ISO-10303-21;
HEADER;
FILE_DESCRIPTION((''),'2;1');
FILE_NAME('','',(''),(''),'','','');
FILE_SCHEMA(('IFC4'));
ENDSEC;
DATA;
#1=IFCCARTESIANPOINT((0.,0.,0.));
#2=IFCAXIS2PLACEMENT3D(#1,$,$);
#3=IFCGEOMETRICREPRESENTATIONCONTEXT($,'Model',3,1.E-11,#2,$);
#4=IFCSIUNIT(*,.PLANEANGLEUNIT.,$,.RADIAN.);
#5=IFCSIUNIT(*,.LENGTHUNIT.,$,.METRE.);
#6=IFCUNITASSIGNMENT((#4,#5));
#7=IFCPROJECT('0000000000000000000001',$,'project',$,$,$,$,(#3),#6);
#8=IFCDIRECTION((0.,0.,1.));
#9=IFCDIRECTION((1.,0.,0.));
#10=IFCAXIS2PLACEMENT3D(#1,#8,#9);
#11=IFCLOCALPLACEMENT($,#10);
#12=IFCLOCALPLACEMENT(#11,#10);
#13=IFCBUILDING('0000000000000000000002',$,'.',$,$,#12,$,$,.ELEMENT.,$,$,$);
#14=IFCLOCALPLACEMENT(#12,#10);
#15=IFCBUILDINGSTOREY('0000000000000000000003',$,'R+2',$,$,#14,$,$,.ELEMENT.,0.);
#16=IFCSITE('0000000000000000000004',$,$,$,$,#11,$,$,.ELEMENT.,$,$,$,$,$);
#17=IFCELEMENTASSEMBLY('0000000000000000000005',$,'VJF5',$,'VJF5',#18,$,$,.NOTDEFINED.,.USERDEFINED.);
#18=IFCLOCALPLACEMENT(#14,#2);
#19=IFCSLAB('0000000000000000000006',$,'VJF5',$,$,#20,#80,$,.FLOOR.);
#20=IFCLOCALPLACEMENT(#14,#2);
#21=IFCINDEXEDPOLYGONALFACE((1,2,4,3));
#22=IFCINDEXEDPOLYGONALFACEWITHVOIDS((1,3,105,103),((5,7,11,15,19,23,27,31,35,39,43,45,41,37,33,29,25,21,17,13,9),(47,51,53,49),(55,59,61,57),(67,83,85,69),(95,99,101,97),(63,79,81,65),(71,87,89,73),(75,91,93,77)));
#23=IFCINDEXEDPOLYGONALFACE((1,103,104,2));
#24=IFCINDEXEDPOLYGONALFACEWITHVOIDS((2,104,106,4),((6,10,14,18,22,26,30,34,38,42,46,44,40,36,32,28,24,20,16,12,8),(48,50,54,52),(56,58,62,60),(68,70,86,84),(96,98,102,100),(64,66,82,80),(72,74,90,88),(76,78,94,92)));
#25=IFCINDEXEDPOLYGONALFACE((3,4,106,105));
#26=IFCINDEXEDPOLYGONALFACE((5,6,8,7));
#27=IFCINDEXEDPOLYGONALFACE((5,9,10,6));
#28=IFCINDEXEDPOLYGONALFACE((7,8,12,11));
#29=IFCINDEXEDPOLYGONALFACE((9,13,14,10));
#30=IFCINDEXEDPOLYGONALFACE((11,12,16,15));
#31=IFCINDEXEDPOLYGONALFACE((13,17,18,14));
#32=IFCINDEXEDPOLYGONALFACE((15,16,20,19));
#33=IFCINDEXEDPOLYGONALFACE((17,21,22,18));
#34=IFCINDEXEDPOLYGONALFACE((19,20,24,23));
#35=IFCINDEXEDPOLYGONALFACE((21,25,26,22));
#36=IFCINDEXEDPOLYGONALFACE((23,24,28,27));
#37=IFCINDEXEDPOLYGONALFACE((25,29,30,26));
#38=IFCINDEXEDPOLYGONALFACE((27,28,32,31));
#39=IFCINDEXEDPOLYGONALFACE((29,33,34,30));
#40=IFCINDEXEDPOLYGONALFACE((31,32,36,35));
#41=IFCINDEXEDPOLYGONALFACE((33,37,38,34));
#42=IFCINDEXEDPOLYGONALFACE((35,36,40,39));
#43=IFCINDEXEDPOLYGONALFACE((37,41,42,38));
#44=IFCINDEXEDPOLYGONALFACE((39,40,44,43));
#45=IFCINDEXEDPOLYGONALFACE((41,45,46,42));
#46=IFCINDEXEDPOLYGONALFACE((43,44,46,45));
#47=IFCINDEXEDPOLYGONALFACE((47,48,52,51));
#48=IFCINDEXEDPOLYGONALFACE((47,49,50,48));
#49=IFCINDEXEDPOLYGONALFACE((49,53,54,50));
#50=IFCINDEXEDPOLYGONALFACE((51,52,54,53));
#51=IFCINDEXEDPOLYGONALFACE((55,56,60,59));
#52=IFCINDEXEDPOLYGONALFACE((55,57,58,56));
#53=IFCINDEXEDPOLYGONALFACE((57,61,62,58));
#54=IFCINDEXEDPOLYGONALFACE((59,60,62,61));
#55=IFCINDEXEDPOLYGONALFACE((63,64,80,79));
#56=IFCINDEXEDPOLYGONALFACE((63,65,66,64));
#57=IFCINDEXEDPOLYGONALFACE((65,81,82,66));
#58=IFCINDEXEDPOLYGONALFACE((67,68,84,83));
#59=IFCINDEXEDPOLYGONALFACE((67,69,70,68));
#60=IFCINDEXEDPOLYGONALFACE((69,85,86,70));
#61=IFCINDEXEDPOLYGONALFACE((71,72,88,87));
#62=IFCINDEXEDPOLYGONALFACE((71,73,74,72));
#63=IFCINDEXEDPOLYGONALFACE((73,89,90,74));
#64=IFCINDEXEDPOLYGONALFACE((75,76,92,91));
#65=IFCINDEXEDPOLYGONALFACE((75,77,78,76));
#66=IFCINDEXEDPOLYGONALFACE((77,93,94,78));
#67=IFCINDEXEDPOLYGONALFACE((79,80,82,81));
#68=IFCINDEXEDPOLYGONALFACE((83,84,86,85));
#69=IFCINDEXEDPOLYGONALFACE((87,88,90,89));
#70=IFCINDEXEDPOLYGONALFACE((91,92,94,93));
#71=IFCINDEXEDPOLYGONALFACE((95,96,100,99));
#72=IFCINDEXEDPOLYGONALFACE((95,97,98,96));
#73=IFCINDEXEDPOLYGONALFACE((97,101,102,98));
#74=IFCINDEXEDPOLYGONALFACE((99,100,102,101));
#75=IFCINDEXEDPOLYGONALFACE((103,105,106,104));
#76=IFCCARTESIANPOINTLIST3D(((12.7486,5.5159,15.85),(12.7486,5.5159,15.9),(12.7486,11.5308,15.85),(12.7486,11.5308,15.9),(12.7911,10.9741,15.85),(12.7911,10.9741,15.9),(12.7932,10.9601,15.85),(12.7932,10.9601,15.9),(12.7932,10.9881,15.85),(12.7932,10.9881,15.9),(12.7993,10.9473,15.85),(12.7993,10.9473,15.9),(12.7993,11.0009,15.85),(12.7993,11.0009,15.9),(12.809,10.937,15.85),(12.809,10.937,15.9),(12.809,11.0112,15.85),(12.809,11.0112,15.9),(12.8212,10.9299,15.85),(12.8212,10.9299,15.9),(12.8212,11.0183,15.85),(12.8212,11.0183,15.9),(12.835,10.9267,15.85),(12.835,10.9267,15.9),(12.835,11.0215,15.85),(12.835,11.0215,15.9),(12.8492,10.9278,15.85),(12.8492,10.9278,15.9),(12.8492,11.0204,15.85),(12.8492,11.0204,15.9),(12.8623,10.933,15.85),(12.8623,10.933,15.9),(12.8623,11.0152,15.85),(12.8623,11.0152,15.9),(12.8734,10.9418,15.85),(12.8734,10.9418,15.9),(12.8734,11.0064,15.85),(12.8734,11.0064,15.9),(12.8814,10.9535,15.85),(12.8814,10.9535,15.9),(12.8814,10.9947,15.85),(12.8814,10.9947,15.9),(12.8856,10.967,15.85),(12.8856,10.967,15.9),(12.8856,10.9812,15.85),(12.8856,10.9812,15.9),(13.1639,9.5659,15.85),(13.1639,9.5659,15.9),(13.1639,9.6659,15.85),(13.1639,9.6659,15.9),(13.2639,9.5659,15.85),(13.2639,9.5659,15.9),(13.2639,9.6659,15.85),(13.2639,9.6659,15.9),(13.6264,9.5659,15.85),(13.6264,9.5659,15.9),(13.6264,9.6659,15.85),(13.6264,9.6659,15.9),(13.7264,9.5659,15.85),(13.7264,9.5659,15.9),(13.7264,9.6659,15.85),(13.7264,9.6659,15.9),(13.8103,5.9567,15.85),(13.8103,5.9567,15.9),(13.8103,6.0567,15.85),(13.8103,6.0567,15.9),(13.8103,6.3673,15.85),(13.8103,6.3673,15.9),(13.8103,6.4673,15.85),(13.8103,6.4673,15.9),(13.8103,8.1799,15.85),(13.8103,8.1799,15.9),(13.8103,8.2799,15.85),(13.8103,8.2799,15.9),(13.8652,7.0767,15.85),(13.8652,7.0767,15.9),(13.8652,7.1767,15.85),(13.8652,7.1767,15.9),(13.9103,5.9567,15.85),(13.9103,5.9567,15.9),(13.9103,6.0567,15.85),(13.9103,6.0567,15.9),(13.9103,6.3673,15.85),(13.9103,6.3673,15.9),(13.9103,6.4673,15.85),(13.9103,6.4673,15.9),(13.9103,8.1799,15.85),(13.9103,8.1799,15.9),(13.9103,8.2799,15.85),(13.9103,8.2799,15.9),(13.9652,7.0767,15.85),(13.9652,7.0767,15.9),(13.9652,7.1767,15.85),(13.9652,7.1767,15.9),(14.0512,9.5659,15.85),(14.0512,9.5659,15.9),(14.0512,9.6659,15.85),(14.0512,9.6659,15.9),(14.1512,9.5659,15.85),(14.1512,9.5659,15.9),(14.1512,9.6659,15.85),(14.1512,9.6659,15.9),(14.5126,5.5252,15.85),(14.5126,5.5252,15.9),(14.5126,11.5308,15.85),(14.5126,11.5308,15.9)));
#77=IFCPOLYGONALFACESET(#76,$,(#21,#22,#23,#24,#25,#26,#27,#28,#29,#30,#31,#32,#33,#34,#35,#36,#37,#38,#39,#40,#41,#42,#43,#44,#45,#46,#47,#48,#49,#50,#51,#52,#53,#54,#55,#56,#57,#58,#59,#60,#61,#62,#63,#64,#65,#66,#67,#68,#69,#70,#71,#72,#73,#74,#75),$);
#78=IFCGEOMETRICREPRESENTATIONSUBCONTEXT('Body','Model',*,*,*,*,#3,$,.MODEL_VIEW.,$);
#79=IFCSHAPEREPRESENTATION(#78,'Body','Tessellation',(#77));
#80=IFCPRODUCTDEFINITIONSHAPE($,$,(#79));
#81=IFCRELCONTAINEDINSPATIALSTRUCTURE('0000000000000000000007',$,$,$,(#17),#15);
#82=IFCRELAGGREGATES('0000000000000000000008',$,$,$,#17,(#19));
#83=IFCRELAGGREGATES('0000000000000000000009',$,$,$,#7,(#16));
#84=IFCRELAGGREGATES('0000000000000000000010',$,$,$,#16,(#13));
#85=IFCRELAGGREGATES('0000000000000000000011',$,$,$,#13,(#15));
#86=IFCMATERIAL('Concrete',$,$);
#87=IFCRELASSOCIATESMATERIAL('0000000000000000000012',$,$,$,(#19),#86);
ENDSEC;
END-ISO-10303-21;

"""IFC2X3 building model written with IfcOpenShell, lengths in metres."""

from ifc_helpers import new_model, si_unit, frame, origin, origin_with_axes, origin_2d_with_axis, place, context, subcontext, project, spatial, polyline, circle, outline, extrude, material, element, aggregate, save


model = new_model("IFC2X3")

# Units and contexts
model_context = context("Model", 3, precision=1e-11, world=origin())
body_context = subcontext(model_context, "Body", "Model", "MODEL_VIEW")
ifc_project = project(units=[si_unit("PLANEANGLEUNIT", "RADIAN"), si_unit("LENGTHUNIT", "METRE")], contexts=[model_context])

# Site, building, storey
site_placement = place(None, origin_with_axes())
site = spatial("IfcSite", under=ifc_project, at=site_placement, CompositionType="ELEMENT")
building_placement = place(site_placement, origin_with_axes())
building = spatial("IfcBuilding", under=site, at=building_placement, Name=".", CompositionType="ELEMENT")
storey_placement = place(building_placement, origin_with_axes())
storey = spatial("IfcBuildingStorey", under=building, at=storey_placement, Name="R+2", CompositionType="ELEMENT", Elevation=0.0)

# Element assembly, slab, openings
assembly_placement = place(storey_placement, origin_with_axes())
assembly = element("IfcElementAssembly", 1, at=assembly_placement, inside=storey, Name="VJF5", ObjectType="VJF5", AssemblyPlace="NOTDEFINED", PredefinedType="USERDEFINED")
ifc_material = material(Name="Concrete")
slab_placement = place(assembly_placement, frame((14.5126, 5.5159, 15.85), z_axis=(0.0, 0.0, 1.0), x_axis=(0.0, 1.0, 0.0)))
slab = element("IfcSlab", 2, at=slab_placement, material=ifc_material, Name="VJF5", PredefinedType="FLOOR", context=body_context, shape_type="SweptSolid", body=[
    extrude(outline(polyline([(0.0, -0.0093), (0.0, -6.0149), (1.7641, -6.0149), (1.764, 0.0), (0.0, -0.0093)])), frame((0.0, 0.0, 0.0), z_axis=(0.0, 0.0, 1.0), x_axis=(0.0, 1.0, 0.0)), (0.0, 0.0, 1.0), 0.05),
])
opening_1_placement = place(slab_placement, frame((5.4582, 1.6741, 0.0), z_axis=(0.0, 0.0, 1.0), x_axis=(1.0, 0.0, 0.0)))
element("IfcOpeningElement", 3, at=opening_1_placement, cuts=slab, ObjectType="Opening", context=body_context, shape_type="SweptSolid", body=[
    extrude(circle(Radius=0.0475, at=origin_2d_with_axis()), frame((0.0, 0.0, 0.0), z_axis=(0.0, 0.0, 1.0), x_axis=(0.0, 1.0, 0.0)), (0.0, 0.0, 1.0), 0.05),
])
opening_2_placement = place(slab_placement, origin_with_axes())
element("IfcOpeningElement", 4, at=opening_2_placement, cuts=slab, ObjectType="Opening", context=body_context, shape_type="SweptSolid", body=[
    extrude(outline(polyline([(0.5474, -1.5607), (0.5474, -1.6607), (0.6474, -1.6607), (0.6474, -1.5607), (0.5474, -1.5607)])), frame((0.0, 0.0, 0.0), z_axis=(0.0, 0.0, 1.0), x_axis=(0.0, 1.0, 0.0)), (0.0, 0.0, 1.0), 0.05),
])
opening_3_placement = place(slab_placement, origin_with_axes())
element("IfcOpeningElement", 5, at=opening_3_placement, cuts=slab, ObjectType="Opening", context=body_context, shape_type="SweptSolid", body=[
    extrude(outline(polyline([(0.6023, -0.4408), (0.6023, -0.5408), (0.7023, -0.5408), (0.7023, -0.4408), (0.6023, -0.4408)])), frame((0.0, 0.0, 0.0), z_axis=(0.0, 0.0, 1.0), x_axis=(0.0, 1.0, 0.0)), (0.0, 0.0, 1.0), 0.05),
])
opening_4_placement = place(slab_placement, origin_with_axes())
element("IfcOpeningElement", 6, at=opening_4_placement, cuts=slab, ObjectType="Opening", context=body_context, shape_type="SweptSolid", body=[
    extrude(outline(polyline([(0.6023, -0.8514), (0.6023, -0.9514), (0.7023, -0.9514), (0.7023, -0.8514), (0.6023, -0.8514)])), frame((0.0, 0.0, 0.0), z_axis=(0.0, 0.0, 1.0), x_axis=(0.0, 1.0, 0.0)), (0.0, 0.0, 1.0), 0.05),
])
opening_5_placement = place(slab_placement, origin_with_axes())
element("IfcOpeningElement", 7, at=opening_5_placement, cuts=slab, ObjectType="Opening", context=body_context, shape_type="SweptSolid", body=[
    extrude(outline(polyline([(0.6023, -2.664), (0.6023, -2.764), (0.7023, -2.764), (0.7023, -2.664), (0.6023, -2.664)])), frame((0.0, 0.0, 0.0), z_axis=(0.0, 0.0, 1.0), x_axis=(0.0, 1.0, 0.0)), (0.0, 0.0, 1.0), 0.05),
])
opening_6_placement = place(slab_placement, origin_with_axes())
element("IfcOpeningElement", 8, at=opening_6_placement, cuts=slab, ObjectType="Opening", context=body_context, shape_type="SweptSolid", body=[
    extrude(outline(polyline([(0.3614, -4.05), (0.3614, -4.15), (0.4614, -4.15), (0.4614, -4.05), (0.3614, -4.05)])), frame((0.0, 0.0, 0.0), z_axis=(0.0, 0.0, 1.0), x_axis=(0.0, 1.0, 0.0)), (0.0, 0.0, 1.0), 0.05),
])
opening_7_placement = place(slab_placement, origin_with_axes())
element("IfcOpeningElement", 9, at=opening_7_placement, cuts=slab, ObjectType="Opening", context=body_context, shape_type="SweptSolid", body=[
    extrude(outline(polyline([(0.7863, -4.05), (0.7863, -4.15), (0.8863, -4.15), (0.8863, -4.05), (0.7863, -4.05)])), frame((0.0, 0.0, 0.0), z_axis=(0.0, 0.0, 1.0), x_axis=(0.0, 1.0, 0.0)), (0.0, 0.0, 1.0), 0.05),
])
opening_8_placement = place(slab_placement, origin_with_axes())
element("IfcOpeningElement", 10, at=opening_8_placement, cuts=slab, ObjectType="Opening", context=body_context, shape_type="SweptSolid", body=[
    extrude(outline(polyline([(1.2487, -4.05), (1.2487, -4.15), (1.3487, -4.15), (1.3487, -4.05), (1.2487, -4.05)])), frame((0.0, 0.0, 0.0), z_axis=(0.0, 0.0, 1.0), x_axis=(0.0, 1.0, 0.0)), (0.0, 0.0, 1.0), 0.05),
])
aggregate(assembly, [slab])

save(model, "model.ifc")
